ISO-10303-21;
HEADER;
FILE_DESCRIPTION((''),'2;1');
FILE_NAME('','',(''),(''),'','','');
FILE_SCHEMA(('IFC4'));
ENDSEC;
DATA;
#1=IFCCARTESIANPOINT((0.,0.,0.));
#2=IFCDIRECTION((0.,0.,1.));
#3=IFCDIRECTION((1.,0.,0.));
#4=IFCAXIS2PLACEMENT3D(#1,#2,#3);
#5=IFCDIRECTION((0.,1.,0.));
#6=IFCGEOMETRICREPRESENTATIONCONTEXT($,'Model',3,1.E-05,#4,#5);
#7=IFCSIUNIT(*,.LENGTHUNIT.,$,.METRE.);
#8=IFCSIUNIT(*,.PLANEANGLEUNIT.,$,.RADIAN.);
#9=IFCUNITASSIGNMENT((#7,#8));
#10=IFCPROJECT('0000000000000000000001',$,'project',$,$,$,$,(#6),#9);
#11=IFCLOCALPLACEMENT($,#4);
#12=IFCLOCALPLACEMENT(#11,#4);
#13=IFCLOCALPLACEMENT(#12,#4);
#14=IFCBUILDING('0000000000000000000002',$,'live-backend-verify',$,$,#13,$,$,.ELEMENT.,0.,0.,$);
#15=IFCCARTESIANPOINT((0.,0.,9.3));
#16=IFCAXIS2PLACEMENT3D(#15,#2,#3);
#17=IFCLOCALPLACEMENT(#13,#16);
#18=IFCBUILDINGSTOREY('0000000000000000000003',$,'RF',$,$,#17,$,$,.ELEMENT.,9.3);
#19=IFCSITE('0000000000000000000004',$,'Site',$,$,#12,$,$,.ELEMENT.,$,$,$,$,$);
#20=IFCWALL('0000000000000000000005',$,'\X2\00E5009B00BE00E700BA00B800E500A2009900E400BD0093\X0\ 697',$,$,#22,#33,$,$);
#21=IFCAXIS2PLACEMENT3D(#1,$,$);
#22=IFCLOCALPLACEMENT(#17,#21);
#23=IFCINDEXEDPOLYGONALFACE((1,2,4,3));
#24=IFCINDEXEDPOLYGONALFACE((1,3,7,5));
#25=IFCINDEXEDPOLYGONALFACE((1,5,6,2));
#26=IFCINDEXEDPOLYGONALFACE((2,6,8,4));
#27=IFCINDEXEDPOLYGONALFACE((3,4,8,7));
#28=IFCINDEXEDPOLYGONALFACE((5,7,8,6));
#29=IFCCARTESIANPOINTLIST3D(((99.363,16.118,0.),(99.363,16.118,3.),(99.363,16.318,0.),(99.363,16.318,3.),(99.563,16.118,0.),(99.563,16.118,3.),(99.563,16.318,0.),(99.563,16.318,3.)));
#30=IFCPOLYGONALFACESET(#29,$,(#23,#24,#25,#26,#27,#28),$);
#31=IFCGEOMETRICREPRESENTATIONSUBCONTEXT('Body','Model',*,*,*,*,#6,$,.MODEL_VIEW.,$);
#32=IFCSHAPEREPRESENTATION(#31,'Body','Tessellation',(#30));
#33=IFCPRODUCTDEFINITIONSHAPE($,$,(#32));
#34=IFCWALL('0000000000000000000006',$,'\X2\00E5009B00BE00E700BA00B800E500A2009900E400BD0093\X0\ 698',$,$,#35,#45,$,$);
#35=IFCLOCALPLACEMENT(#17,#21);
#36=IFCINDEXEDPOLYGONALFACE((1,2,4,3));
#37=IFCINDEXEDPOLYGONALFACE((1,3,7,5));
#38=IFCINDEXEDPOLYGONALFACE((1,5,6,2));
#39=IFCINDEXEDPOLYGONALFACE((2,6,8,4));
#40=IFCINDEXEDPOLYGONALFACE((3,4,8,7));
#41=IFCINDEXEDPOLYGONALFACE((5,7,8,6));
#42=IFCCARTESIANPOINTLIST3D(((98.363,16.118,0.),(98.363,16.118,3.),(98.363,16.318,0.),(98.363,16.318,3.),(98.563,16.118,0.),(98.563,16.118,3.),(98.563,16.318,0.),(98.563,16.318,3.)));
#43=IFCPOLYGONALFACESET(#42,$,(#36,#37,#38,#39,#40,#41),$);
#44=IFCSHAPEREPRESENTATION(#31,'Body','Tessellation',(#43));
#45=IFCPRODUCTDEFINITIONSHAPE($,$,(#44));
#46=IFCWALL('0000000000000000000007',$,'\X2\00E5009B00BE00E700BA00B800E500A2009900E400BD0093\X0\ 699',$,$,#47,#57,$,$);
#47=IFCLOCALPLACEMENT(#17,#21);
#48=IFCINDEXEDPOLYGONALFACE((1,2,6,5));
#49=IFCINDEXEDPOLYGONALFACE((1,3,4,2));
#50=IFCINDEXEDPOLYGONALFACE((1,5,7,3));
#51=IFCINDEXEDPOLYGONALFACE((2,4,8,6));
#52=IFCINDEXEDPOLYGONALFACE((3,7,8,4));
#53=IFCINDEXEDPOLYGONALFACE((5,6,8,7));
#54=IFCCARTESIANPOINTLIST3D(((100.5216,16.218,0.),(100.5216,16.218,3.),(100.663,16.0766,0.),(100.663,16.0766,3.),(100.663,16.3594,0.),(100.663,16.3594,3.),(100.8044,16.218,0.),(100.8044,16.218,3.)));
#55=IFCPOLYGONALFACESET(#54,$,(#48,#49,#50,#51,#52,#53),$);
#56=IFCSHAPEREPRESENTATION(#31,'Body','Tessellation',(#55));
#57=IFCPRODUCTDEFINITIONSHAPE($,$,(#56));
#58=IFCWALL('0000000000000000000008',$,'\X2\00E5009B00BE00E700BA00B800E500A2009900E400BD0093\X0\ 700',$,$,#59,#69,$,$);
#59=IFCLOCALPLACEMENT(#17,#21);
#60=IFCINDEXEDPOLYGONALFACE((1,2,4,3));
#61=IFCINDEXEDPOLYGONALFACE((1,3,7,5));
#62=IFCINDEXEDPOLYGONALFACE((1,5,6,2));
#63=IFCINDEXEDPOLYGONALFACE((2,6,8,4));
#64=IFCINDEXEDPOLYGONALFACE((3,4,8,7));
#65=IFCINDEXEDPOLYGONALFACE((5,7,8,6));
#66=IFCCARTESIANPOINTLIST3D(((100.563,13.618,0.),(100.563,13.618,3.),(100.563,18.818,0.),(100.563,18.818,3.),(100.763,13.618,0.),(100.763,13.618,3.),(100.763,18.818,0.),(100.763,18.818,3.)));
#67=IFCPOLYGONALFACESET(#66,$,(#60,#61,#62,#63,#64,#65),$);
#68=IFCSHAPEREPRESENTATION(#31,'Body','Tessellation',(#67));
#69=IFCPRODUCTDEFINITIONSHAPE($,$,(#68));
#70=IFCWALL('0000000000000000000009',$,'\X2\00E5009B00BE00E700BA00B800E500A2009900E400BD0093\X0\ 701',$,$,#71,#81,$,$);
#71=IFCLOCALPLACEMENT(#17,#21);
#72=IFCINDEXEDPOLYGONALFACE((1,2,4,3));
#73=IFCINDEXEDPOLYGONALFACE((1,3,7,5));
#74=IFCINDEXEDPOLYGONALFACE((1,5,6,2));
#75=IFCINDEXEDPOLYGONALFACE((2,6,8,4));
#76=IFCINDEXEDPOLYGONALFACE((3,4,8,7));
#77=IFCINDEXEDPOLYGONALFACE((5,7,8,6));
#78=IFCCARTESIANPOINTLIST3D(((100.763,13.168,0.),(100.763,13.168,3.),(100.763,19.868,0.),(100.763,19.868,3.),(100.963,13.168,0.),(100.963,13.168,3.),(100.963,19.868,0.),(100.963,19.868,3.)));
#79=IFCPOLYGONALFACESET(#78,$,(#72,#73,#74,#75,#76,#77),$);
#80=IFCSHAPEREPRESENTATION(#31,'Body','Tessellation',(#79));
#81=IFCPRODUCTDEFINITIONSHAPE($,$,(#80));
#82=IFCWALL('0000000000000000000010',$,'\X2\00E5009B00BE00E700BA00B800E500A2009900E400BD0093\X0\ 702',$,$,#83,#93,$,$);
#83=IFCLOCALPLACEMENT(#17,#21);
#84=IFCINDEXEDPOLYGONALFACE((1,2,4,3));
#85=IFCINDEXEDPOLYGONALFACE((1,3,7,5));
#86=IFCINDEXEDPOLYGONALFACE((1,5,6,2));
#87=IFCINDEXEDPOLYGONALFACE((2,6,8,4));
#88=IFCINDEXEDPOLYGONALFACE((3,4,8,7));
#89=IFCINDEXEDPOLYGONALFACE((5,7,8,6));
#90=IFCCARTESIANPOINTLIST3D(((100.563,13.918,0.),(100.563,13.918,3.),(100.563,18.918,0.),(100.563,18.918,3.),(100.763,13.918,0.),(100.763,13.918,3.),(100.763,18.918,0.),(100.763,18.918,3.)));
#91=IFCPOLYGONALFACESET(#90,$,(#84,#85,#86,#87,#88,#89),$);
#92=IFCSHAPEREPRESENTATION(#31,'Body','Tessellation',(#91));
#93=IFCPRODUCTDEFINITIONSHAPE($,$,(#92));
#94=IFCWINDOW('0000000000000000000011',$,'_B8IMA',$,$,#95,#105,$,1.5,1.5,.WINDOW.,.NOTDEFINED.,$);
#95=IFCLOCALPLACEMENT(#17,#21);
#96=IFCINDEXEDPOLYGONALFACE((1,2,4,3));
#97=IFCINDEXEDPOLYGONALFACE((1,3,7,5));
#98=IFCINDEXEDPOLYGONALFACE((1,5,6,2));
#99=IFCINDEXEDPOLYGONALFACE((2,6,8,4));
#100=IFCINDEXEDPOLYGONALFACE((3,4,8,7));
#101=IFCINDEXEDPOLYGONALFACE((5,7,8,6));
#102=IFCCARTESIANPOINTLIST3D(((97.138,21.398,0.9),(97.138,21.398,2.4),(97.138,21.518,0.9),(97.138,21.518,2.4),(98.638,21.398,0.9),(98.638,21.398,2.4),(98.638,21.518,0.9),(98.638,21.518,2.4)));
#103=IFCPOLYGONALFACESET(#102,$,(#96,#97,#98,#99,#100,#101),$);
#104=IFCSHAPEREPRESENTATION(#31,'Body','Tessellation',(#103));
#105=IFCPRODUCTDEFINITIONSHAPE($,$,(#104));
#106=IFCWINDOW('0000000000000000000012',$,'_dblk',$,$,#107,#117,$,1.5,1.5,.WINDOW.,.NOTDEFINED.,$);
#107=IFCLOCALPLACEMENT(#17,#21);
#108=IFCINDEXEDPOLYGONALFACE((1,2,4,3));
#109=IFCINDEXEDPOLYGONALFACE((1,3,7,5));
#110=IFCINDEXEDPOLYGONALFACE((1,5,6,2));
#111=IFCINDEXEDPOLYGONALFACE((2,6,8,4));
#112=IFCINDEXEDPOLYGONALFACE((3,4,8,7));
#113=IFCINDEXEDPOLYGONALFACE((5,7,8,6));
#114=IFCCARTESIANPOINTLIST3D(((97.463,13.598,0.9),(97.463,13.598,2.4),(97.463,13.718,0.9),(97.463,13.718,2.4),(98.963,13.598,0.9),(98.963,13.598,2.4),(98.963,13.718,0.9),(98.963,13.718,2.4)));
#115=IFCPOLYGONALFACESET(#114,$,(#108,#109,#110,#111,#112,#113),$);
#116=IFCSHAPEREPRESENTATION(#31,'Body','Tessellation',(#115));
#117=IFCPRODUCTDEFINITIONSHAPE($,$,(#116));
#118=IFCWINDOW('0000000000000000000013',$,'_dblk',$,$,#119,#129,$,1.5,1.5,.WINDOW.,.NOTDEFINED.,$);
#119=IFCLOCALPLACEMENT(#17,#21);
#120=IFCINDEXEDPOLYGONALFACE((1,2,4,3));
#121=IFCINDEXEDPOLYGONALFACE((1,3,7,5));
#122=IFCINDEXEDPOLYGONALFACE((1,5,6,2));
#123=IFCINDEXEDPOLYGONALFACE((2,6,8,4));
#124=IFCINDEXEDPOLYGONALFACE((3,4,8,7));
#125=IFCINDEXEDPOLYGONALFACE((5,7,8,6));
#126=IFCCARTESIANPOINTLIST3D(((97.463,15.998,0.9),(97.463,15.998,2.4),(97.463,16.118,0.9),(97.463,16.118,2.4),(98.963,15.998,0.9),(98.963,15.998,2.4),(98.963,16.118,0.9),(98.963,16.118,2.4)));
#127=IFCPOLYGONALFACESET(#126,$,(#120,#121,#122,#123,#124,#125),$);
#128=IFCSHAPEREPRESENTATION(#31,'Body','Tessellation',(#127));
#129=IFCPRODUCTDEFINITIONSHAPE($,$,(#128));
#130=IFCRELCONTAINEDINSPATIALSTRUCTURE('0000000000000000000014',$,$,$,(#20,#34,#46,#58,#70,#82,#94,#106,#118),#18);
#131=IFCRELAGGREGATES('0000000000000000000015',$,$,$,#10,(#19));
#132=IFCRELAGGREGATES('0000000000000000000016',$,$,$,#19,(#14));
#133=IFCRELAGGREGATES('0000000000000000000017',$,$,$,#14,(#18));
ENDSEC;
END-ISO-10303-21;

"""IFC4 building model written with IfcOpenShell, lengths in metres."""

from ifc_helpers import new_model, si_unit, direction, frame, frame_2d, origin_with_axes, place, context, subcontext, project, spatial, rectangle, extrude, element, save


model = new_model("IFC4")

# Units and contexts
model_context = context("Model", 3, precision=1e-05, world=origin_with_axes(), true_north=direction((0.0, 1.0, 0.0)))
body_context = subcontext(model_context, "Body", "Model", "MODEL_VIEW")
ifc_project = project(units=[si_unit("LENGTHUNIT", "METRE"), si_unit("PLANEANGLEUNIT", "RADIAN")], contexts=[model_context])

# Site, building, storey
placement = place(None, origin_with_axes())
site_placement = place(placement, origin_with_axes())
site = spatial("IfcSite", under=ifc_project, at=site_placement, Name="Site", CompositionType="ELEMENT")
building_placement = place(site_placement, origin_with_axes())
building = spatial("IfcBuilding", under=site, at=building_placement, Name="live-backend-verify", CompositionType="ELEMENT", ElevationOfRefHeight=0.0, ElevationOfTerrain=0.0)
storey_placement = place(building_placement, frame((0.0, 0.0, 9.3), z_axis=(0.0, 0.0, 1.0), x_axis=(1.0, 0.0, 0.0)))
storey = spatial("IfcBuildingStorey", under=building, at=storey_placement, Name="RF", CompositionType="ELEMENT", Elevation=9.3)

# Walls
for number, where, z_axis, x_axis, name in (
    (1, (99.463, 16.218, 0.0), (0.0, 0.0, 1.0), (0.0, -1.0, 0.0), "å\u009b¾çº¸å¢\u0099ä½\u0093 697"),
    (2, (98.463, 16.218, 0.0), (0.0, 0.0, 1.0), (0.0, -1.0, 0.0), "å\u009b¾çº¸å¢\u0099ä½\u0093 698"),
    (3, (100.663, 16.218, 0.0), (0.0, 0.0, 1.0), (-0.707107, -0.707107, 0.0), "å\u009b¾çº¸å¢\u0099ä½\u0093 699"),
):
    element("IfcWall", number, at=place(storey_placement, frame(where, z_axis=z_axis, x_axis=x_axis)), inside=storey, Name=name, context=body_context, shape_type="SweptSolid", body=[
        extrude(rectangle(XDim=0.2, YDim=0.2, at=frame_2d((0.0, 0.0), x_axis=(1.0, 0.0, 0.0))), frame((0.0, 0.0, 0.0), z_axis=(0.0, 0.0, 1.0)), (0.0, 0.0, 1.0), 3.0),
    ])
wall_1_placement = place(storey_placement, frame((100.663, 16.218, 0.0), z_axis=(0.0, 0.0, 1.0), x_axis=(0.0, 1.0, 0.0)))
element("IfcWall", 4, at=wall_1_placement, inside=storey, Name="å\u009b¾çº¸å¢\u0099ä½\u0093 700", context=body_context, shape_type="SweptSolid", body=[
    extrude(rectangle(XDim=5.2, YDim=0.2, at=frame_2d((0.0, 0.0), x_axis=(1.0, 0.0, 0.0))), frame((0.0, 0.0, 0.0), z_axis=(0.0, 0.0, 1.0)), (0.0, 0.0, 1.0), 3.0),
])
wall_2_placement = place(storey_placement, frame((100.863, 16.518, 0.0), z_axis=(0.0, 0.0, 1.0), x_axis=(0.0, 1.0, 0.0)))
element("IfcWall", 5, at=wall_2_placement, inside=storey, Name="å\u009b¾çº¸å¢\u0099ä½\u0093 701", context=body_context, shape_type="SweptSolid", body=[
    extrude(rectangle(XDim=6.7, YDim=0.2, at=frame_2d((0.0, 0.0), x_axis=(1.0, 0.0, 0.0))), frame((0.0, 0.0, 0.0), z_axis=(0.0, 0.0, 1.0)), (0.0, 0.0, 1.0), 3.0),
])
wall_3_placement = place(storey_placement, frame((100.663, 16.418, 0.0), z_axis=(0.0, 0.0, 1.0), x_axis=(0.0, 1.0, 0.0)))
element("IfcWall", 6, at=wall_3_placement, inside=storey, Name="å\u009b¾çº¸å¢\u0099ä½\u0093 702", context=body_context, shape_type="SweptSolid", body=[
    extrude(rectangle(XDim=5.0, YDim=0.2, at=frame_2d((0.0, 0.0), x_axis=(1.0, 0.0, 0.0))), frame((0.0, 0.0, 0.0), z_axis=(0.0, 0.0, 1.0)), (0.0, 0.0, 1.0), 3.0),
])

# Windows
for number, where, z_axis, x_axis, name in (
    (7, (97.888, 21.458, 0.9), (0.0, 0.0, 1.0), (1.0, 0.0, 0.0), "_B8IMA"),
    (8, (98.213, 13.658, 0.9), (0.0, 0.0, 1.0), (1.0, 0.0, 0.0), "_dblk"),
    (9, (98.213, 16.058, 0.9), (0.0, 0.0, 1.0), (1.0, 0.0, 0.0), "_dblk"),
):
    element("IfcWindow", number, at=place(storey_placement, frame(where, z_axis=z_axis, x_axis=x_axis)), inside=storey, Name=name, OverallHeight=1.5, OverallWidth=1.5, PartitioningType="NOTDEFINED", PredefinedType="WINDOW", context=body_context, shape_type="SweptSolid", body=[
        extrude(rectangle(XDim=1.5, YDim=0.12, at=frame_2d((0.0, 0.0), x_axis=(1.0, 0.0, 0.0))), frame((0.0, 0.0, 0.0), z_axis=(0.0, 0.0, 1.0)), (0.0, 0.0, 1.0), 1.5),
    ])

save(model, "model.ifc")
